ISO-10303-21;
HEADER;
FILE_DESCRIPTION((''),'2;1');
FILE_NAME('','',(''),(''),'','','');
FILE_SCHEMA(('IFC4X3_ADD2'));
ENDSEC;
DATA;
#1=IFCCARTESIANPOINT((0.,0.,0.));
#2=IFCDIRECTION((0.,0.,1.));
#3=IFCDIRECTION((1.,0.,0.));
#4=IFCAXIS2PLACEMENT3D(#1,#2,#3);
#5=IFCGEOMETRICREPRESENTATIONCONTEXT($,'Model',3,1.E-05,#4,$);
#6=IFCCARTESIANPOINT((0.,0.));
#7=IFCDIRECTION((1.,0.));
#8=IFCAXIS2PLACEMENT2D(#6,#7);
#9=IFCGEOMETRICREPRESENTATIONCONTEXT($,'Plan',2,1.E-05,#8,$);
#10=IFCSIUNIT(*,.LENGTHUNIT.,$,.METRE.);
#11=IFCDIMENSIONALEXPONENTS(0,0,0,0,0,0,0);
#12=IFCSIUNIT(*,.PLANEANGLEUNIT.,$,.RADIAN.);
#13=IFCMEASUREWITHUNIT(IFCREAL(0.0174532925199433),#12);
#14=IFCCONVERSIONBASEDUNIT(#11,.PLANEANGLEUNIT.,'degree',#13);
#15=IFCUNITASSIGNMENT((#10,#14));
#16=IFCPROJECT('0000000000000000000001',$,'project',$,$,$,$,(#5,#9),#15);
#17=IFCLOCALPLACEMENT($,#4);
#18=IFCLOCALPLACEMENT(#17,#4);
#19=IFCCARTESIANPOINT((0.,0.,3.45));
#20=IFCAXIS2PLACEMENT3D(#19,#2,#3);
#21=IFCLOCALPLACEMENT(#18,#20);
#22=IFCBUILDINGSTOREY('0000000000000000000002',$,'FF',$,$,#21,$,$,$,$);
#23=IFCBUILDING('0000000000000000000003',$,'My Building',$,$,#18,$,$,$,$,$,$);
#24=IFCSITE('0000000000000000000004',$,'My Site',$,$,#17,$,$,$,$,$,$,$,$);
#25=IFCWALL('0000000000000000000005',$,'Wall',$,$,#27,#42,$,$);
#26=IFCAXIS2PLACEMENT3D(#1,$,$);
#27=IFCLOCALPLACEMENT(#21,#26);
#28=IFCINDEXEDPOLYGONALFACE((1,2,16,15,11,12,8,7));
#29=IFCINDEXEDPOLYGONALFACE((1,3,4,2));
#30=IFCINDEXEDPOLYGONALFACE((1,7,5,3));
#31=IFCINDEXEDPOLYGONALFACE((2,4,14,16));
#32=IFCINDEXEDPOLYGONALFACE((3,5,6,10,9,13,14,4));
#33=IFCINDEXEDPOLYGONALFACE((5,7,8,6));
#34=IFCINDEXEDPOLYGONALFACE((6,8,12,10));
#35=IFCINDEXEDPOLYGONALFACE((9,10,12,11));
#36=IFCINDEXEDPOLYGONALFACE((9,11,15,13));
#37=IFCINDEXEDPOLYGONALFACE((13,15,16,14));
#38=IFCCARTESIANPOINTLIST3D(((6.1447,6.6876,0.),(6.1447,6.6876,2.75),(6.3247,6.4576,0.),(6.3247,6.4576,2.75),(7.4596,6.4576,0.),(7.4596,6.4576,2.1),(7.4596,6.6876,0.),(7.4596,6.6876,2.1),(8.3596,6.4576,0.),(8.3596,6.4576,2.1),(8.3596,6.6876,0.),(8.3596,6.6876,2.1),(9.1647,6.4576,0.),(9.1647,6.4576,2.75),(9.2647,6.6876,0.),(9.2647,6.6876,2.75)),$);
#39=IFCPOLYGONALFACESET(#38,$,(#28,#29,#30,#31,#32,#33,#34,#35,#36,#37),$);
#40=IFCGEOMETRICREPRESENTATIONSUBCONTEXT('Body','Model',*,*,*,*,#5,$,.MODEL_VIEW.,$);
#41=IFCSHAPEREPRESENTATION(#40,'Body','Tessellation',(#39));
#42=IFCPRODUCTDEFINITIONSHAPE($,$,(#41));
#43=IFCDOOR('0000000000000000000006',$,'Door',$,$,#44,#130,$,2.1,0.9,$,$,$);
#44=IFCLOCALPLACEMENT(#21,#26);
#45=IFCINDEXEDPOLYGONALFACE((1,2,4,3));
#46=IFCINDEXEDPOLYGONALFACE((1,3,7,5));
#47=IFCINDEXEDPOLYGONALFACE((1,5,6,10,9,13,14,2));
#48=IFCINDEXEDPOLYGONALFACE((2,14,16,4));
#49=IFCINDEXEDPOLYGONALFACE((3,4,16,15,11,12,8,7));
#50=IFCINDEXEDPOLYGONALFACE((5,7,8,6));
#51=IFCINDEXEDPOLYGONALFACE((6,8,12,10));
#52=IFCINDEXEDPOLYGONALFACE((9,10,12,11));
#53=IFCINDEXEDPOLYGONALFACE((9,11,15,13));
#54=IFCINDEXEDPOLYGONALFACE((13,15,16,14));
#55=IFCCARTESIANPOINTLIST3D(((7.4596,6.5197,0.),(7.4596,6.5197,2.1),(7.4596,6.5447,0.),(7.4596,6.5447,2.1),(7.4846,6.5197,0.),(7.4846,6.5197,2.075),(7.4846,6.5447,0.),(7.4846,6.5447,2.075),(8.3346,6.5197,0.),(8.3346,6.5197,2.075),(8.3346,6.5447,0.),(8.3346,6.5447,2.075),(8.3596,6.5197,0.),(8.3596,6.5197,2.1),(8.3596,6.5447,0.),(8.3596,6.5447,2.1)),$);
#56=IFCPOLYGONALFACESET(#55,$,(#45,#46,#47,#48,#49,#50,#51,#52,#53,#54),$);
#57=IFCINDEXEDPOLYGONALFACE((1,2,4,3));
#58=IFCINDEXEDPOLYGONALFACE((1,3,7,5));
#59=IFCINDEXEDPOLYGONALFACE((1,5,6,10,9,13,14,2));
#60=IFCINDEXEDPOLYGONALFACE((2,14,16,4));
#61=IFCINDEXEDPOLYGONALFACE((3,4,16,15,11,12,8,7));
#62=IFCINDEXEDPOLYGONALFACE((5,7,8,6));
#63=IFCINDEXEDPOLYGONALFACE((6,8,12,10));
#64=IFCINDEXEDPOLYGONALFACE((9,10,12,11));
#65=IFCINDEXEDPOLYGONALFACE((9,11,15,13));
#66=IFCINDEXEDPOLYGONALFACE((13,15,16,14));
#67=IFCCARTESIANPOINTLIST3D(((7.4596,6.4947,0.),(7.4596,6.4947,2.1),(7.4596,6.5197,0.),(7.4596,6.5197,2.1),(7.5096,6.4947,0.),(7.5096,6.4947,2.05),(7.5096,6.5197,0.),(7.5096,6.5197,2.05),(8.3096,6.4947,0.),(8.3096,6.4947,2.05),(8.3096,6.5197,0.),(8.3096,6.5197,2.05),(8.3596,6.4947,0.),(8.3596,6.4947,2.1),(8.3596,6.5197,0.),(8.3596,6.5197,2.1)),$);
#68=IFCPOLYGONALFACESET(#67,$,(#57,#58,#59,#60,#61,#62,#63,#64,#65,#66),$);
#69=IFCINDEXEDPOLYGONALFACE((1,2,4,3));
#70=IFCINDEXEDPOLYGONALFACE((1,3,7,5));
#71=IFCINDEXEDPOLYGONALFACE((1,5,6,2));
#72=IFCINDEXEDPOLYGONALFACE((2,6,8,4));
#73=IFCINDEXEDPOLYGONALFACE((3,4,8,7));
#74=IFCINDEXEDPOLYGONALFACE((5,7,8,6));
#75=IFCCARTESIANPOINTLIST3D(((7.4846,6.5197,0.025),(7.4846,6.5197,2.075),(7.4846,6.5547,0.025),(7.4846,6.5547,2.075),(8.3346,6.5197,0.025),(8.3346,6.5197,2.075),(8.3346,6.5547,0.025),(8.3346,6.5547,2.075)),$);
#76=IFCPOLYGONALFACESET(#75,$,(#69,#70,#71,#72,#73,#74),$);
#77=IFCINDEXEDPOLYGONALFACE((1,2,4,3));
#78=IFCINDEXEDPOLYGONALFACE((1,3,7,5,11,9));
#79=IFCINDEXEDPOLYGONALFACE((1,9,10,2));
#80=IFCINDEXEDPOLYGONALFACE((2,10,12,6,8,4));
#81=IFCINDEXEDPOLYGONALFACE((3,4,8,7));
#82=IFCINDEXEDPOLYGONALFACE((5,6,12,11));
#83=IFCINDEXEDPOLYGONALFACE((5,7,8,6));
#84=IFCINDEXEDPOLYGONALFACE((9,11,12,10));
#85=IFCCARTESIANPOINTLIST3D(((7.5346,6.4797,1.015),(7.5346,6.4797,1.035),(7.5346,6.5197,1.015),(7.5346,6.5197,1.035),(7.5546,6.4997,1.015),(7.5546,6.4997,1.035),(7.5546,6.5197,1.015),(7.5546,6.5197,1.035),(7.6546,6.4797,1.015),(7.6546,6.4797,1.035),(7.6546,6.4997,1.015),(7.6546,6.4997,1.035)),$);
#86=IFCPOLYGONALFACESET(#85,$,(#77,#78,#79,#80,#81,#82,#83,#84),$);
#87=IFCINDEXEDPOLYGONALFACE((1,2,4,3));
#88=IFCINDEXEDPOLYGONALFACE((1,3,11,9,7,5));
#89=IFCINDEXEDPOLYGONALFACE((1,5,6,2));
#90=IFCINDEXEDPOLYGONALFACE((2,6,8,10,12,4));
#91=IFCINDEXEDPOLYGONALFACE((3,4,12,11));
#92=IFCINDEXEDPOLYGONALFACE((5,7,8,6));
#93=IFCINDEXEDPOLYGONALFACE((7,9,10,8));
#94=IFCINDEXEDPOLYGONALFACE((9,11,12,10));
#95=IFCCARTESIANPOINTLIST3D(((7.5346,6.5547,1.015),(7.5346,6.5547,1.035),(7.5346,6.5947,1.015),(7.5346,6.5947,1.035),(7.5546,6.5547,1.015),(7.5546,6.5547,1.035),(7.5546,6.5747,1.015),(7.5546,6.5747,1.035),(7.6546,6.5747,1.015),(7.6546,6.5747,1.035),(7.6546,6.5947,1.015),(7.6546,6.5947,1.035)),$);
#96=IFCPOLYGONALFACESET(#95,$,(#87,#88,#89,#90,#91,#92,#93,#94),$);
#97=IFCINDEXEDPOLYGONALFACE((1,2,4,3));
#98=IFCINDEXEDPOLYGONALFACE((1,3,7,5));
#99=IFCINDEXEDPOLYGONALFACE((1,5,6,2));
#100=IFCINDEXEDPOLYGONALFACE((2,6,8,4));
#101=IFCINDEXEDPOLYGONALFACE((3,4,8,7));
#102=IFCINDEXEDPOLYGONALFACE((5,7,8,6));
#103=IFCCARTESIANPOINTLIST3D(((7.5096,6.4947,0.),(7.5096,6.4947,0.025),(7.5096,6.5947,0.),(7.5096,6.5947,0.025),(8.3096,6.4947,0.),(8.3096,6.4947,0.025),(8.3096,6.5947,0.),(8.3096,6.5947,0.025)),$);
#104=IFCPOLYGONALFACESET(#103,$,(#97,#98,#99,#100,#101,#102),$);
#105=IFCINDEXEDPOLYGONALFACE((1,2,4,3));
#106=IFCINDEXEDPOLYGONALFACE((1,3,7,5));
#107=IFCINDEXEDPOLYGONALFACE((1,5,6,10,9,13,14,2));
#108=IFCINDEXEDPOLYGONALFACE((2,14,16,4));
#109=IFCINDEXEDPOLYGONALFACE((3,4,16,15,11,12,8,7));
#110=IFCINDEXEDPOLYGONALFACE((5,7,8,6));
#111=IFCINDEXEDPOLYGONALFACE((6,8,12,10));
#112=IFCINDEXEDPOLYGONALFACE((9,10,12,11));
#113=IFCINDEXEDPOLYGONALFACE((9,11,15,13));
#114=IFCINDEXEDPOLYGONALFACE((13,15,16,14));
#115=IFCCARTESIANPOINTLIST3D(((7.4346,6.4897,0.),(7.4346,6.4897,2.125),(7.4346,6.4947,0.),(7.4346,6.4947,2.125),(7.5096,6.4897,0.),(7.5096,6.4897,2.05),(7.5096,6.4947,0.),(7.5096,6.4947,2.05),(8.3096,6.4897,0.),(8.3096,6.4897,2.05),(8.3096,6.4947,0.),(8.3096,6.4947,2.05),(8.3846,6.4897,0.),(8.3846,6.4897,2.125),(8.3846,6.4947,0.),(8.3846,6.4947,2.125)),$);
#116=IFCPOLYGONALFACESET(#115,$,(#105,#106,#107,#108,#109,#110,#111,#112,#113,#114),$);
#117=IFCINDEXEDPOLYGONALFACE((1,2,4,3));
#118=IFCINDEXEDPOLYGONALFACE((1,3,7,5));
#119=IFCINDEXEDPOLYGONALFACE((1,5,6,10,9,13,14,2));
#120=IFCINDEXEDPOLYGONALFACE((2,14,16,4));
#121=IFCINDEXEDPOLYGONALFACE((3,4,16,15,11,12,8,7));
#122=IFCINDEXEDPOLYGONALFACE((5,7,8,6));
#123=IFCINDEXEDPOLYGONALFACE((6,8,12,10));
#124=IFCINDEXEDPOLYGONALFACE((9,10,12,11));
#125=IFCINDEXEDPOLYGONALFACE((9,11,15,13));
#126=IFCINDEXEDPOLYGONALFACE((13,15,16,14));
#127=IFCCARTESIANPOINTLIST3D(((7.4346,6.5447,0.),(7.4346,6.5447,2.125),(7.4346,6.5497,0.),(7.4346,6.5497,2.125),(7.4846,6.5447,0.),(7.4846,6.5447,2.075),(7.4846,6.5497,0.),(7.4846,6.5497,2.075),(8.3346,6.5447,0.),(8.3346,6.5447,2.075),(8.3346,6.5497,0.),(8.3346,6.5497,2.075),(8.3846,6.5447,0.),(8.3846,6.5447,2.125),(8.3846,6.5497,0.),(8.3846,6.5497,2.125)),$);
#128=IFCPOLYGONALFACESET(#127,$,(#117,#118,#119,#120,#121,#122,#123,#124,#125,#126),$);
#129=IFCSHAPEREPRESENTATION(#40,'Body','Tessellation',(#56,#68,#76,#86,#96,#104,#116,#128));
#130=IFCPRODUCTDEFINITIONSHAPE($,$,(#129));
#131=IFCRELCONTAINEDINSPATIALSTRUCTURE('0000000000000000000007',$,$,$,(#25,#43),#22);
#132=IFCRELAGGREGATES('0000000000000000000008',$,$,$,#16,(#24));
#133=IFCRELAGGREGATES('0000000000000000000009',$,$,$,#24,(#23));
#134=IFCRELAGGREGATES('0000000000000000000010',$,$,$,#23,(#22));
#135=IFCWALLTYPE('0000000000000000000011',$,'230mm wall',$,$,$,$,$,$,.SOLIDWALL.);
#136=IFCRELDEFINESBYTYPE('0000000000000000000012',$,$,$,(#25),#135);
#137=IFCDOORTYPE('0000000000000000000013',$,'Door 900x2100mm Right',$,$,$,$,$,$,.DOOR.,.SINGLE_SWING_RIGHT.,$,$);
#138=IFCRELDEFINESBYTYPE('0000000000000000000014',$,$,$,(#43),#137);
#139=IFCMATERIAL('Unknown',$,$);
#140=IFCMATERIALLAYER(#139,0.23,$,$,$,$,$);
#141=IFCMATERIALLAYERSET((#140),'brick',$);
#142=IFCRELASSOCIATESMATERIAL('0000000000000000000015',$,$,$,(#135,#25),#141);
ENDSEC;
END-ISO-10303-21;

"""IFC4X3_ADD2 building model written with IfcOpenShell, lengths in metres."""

from ifc_helpers import new_model, entity, si_unit, converted_unit, frame, origin_with_axes, origin_2d_with_axis, place, context, subcontext, project, spatial, line, indexed_curve, outline, extrude, shape, source, transform, mapped, material, layer, layer_set, layer_usage, type_object, type_shapes, element, fill, save


model = new_model("IFC4X3_ADD2")

# Units and contexts
model_context = context("Model", 3, precision=1e-05, world=origin_with_axes())
plan_context = context("Plan", 2, precision=1e-05, world=origin_2d_with_axis())
body_context_1 = subcontext(model_context, "Body", "Model", "MODEL_VIEW")
body_context_2 = subcontext(plan_context, "Body", "Plan", "PLAN_VIEW")
ifc_project = project(units=[si_unit("LENGTHUNIT", "METRE"), converted_unit("PLANEANGLEUNIT", "degree", entity("IfcReal", 0.0174532925199433), si_unit("PLANEANGLEUNIT", "RADIAN"), dimensions=[0, 0, 0, 0, 0, 0, 0])], contexts=[model_context, plan_context])

# Site, building, storey
site_placement = place(None, origin_with_axes())
site = spatial("IfcSite", under=ifc_project, at=site_placement, Name="My Site")
building_placement = place(site_placement, origin_with_axes())
building = spatial("IfcBuilding", under=site, at=building_placement, Name="My Building")
storey_placement = place(building_placement, frame((0.0, 0.0, 3.45), z_axis=(0.0, 0.0, 1.0), x_axis=(1.0, 0.0, 0.0)))
storey = spatial("IfcBuildingStorey", under=building, at=storey_placement, Name="FF")

# Shared definitions
ifc_material = material(Name="Unknown")

# Wall, opening, door
ifc_layer_1 = layer(ifc_material, 0.23)
ifc_layer_set_1 = layer_set([ifc_layer_1], Name="brick")
wall_type_1 = type_object("IfcWallType", Name="230mm wall", PredefinedType="SOLIDWALL", material=ifc_layer_set_1)
ifc_layer_usage_1 = layer_usage(ifc_layer_set_1, "AXIS2", "POSITIVE", 0.0)
wall_1_placement = place(storey_placement, frame((9.2647, 6.6876, 0.0), z_axis=(0.0, 0.0, 1.0), x_axis=(-1.0, 0.0, 0.0)))
wall_1 = element("IfcWall", 1, at=wall_1_placement, inside=storey, type_object=wall_type_1, material=ifc_layer_usage_1, Name="Wall", context=body_context_1, shape_type="SweptSolid", body=[
    extrude(outline(indexed_curve([(0.0, 0.0), (0.1, 0.23), (2.94, 0.23), (3.12, 0.0)], segments=[line(1, 2, 3, 4, 1)])), origin_with_axes(), (0.0, 0.0, 1.0), 2.75),
])
shared_shape_1 = source(origin_with_axes(), body_context_1, "Body", "SolidModel", [
    extrude(outline(indexed_curve([(0.0, 0.0), (0.9, 0.0), (0.9, 2.1), (0.0, 2.1)], segments=[line(1, 2, 3, 4, 1)])), frame((0.0, -0.6, 0.0), z_axis=(0.0, -1.0, 0.0), x_axis=(1.0, 0.0, 0.0)), (0.0, 0.0, -1.0), 1.2),
])
opening_1_placement = place(wall_1_placement, frame((1.8051, 0.0801, 0.0), z_axis=(0.0, 0.0, 1.0), x_axis=(-1.0, 0.0, 0.0)))
opening_1 = element("IfcOpeningElement", 2, at=opening_1_placement, cuts=wall_1, PredefinedType="OPENING", context=body_context_1, shape_type="MappedRepresentation", body=[
    mapped(shared_shape_1, transform((0.0, 0.0, 0.0), x_axis=(1.0, 0.0, 0.0), y_axis=(0.0, 1.0, 0.0), z_axis=(0.0, 0.0, 1.0), scale=1.0)),
])
door_type_1 = type_object("IfcDoorType", Name="Door 900x2100mm Right", OperationType="SINGLE_SWING_RIGHT", PredefinedType="DOOR")
shared_shape_2 = source(origin_with_axes(), body_context_1, "Body", "SweptSolid", [
    extrude(outline(indexed_curve([(0.0, 0.0), (0.0, 2.1), (0.9, 2.1), (0.9, 0.0), (0.875, 0.0), (0.875, 2.075), (0.025, 2.075), (0.025, 0.0)], segments=[line(1, 2, 3, 4, 5, 6, 7, 8, 1)])), frame((0.0, 0.025, 0.0), z_axis=(0.0, -1.0, 0.0), x_axis=(1.0, 0.0, 0.0)), (0.0, 0.0, -1.0), 0.025),
    extrude(outline(indexed_curve([(0.0, 0.0), (0.0, 2.1), (0.9, 2.1), (0.9, 0.0), (0.85, 0.0), (0.85, 2.05), (0.05, 2.05), (0.05, 0.0)], segments=[line(1, 2, 3, 4, 5, 6, 7, 8, 1)])), frame((0.0, 0.0, 0.0), z_axis=(0.0, -1.0, 0.0), x_axis=(1.0, 0.0, 0.0)), (0.0, 0.0, -1.0), 0.025),
    extrude(outline(indexed_curve([(0.0, 0.0), (0.85, 0.0), (0.85, 0.035), (0.0, 0.035)], segments=[line(1, 2, 3, 4, 1)])), frame((0.025, 0.025, 0.025), z_axis=(0.0, 0.0, 1.0), x_axis=(1.0, 0.0, 0.0)), (0.0, 0.0, 1.0), 2.05),
    extrude(outline(indexed_curve([(0.0, 0.0), (0.0, -0.04), (0.12, -0.04), (0.12, -0.02), (0.02, -0.02), (0.02, 0.0)], segments=[line(1, 2, 3, 4, 5, 6, 1)])), frame((0.075, 0.025, 1.015), z_axis=(0.0, 0.0, 1.0), x_axis=(1.0, 0.0, 0.0)), (0.0, 0.0, 1.0), 0.02),
    extrude(outline(indexed_curve([(0.0, 0.0), (0.0, 0.04), (0.12, 0.04), (0.12, 0.02), (0.02, 0.02), (0.02, 0.0)], segments=[line(1, 2, 3, 4, 5, 6, 1)])), frame((0.075, 0.06, 1.015), z_axis=(0.0, 0.0, 1.0), x_axis=(1.0, 0.0, 0.0)), (0.0, 0.0, 1.0), 0.02),
    extrude(outline(indexed_curve([(0.0, 0.0), (0.8, 0.0), (0.8, 0.1), (0.0, 0.1)], segments=[line(1, 2, 3, 4, 1)])), frame((0.05, 0.0, 0.0), z_axis=(0.0, 0.0, 1.0), x_axis=(1.0, 0.0, 0.0)), (0.0, 0.0, 1.0), 0.025),
    extrude(outline(indexed_curve([(0.0, 0.0), (0.0, 2.125), (0.95, 2.125), (0.95, 0.0), (0.875, 0.0), (0.875, 2.05), (0.075, 2.05), (0.075, 0.0)], segments=[line(1, 2, 3, 4, 5, 6, 7, 8, 1)])), frame((-0.025, -0.005, 0.0), z_axis=(0.0, -1.0, 0.0), x_axis=(1.0, 0.0, 0.0)), (0.0, 0.0, -1.0), 0.005),
    extrude(outline(indexed_curve([(0.0, 0.0), (0.0, 2.125), (0.95, 2.125), (0.95, 0.0), (0.9, 0.0), (0.9, 2.075), (0.05, 2.075), (0.05, 0.0)], segments=[line(1, 2, 3, 4, 5, 6, 7, 8, 1)])), frame((-0.025, 0.05, 0.0), z_axis=(0.0, -1.0, 0.0), x_axis=(1.0, 0.0, 0.0)), (0.0, 0.0, -1.0), 0.005),
])
shared_shape_3 = source(origin_with_axes(), body_context_2, "Body", "Curve2D", [
    entity("IfcIndexedPolyCurve", entity("IfcCartesianPointList2D", [[0.0, 0.0], [0.0, 0.05], [0.025, 0.05], [0.025, 0.025], [0.05, 0.025], [0.05, 0.0]]), [entity("IfcLineIndex", [1, 2, 3, 4, 5, 6, 1])]),
    entity("IfcIndexedPolyCurve", entity("IfcCartesianPointList2D", [[0.9, 0.0], [0.9, 0.05], [0.875, 0.05], [0.875, 0.025], [0.85, 0.025], [0.85, 0.0]]), [entity("IfcLineIndex", [1, 2, 3, 4, 5, 6, 1])]),
    entity("IfcTrimmedCurve", entity("IfcEllipse", entity("IfcAxis2Placement2D", entity("IfcCartesianPoint", [0.84, 0.05]), entity("IfcDirection", [1.0, 0.0])), 0.815, 0.85), [entity("IfcCartesianPoint", [0.84, 0.9])], [entity("IfcCartesianPoint", [0.025, 0.05])], True, "CARTESIAN"),
    entity("IfcIndexedPolyCurve", entity("IfcCartesianPointList2D", [[0.875, 0.05], [0.84, 0.05], [0.84, 0.9], [0.875, 0.9]]), [entity("IfcLineIndex", [1, 2, 3, 4, 1])]),
])
type_shapes(door_type_1, [shared_shape_2, shared_shape_3])
door_1_placement = place(opening_1_placement, frame((0.0, -0.1128, 0.0), z_axis=(0.0, 0.0, 1.0), x_axis=(1.0, 0.0, 0.0)))
door_1 = element("IfcDoor", 3, at=door_1_placement, inside=storey, type_object=door_type_1, Name="Door", OverallHeight=2.1, OverallWidth=0.9, shapes=[
    shape(body_context_1, "Body", "MappedRepresentation", [mapped(shared_shape_2, transform((0.0, 0.0, 0.0), x_axis=(1.0, 0.0, 0.0), y_axis=(0.0, 1.0, 0.0), z_axis=(0.0, 0.0, 1.0), scale=1.0))]),
    shape(body_context_2, "Body", "MappedRepresentation", [mapped(shared_shape_3, transform((0.0, 0.0, 0.0), x_axis=(1.0, 0.0, 0.0), y_axis=(0.0, 1.0, 0.0), z_axis=(0.0, 0.0, 1.0), scale=1.0))]),
])
fill(opening_1, door_1)

save(model, "model.ifc")
